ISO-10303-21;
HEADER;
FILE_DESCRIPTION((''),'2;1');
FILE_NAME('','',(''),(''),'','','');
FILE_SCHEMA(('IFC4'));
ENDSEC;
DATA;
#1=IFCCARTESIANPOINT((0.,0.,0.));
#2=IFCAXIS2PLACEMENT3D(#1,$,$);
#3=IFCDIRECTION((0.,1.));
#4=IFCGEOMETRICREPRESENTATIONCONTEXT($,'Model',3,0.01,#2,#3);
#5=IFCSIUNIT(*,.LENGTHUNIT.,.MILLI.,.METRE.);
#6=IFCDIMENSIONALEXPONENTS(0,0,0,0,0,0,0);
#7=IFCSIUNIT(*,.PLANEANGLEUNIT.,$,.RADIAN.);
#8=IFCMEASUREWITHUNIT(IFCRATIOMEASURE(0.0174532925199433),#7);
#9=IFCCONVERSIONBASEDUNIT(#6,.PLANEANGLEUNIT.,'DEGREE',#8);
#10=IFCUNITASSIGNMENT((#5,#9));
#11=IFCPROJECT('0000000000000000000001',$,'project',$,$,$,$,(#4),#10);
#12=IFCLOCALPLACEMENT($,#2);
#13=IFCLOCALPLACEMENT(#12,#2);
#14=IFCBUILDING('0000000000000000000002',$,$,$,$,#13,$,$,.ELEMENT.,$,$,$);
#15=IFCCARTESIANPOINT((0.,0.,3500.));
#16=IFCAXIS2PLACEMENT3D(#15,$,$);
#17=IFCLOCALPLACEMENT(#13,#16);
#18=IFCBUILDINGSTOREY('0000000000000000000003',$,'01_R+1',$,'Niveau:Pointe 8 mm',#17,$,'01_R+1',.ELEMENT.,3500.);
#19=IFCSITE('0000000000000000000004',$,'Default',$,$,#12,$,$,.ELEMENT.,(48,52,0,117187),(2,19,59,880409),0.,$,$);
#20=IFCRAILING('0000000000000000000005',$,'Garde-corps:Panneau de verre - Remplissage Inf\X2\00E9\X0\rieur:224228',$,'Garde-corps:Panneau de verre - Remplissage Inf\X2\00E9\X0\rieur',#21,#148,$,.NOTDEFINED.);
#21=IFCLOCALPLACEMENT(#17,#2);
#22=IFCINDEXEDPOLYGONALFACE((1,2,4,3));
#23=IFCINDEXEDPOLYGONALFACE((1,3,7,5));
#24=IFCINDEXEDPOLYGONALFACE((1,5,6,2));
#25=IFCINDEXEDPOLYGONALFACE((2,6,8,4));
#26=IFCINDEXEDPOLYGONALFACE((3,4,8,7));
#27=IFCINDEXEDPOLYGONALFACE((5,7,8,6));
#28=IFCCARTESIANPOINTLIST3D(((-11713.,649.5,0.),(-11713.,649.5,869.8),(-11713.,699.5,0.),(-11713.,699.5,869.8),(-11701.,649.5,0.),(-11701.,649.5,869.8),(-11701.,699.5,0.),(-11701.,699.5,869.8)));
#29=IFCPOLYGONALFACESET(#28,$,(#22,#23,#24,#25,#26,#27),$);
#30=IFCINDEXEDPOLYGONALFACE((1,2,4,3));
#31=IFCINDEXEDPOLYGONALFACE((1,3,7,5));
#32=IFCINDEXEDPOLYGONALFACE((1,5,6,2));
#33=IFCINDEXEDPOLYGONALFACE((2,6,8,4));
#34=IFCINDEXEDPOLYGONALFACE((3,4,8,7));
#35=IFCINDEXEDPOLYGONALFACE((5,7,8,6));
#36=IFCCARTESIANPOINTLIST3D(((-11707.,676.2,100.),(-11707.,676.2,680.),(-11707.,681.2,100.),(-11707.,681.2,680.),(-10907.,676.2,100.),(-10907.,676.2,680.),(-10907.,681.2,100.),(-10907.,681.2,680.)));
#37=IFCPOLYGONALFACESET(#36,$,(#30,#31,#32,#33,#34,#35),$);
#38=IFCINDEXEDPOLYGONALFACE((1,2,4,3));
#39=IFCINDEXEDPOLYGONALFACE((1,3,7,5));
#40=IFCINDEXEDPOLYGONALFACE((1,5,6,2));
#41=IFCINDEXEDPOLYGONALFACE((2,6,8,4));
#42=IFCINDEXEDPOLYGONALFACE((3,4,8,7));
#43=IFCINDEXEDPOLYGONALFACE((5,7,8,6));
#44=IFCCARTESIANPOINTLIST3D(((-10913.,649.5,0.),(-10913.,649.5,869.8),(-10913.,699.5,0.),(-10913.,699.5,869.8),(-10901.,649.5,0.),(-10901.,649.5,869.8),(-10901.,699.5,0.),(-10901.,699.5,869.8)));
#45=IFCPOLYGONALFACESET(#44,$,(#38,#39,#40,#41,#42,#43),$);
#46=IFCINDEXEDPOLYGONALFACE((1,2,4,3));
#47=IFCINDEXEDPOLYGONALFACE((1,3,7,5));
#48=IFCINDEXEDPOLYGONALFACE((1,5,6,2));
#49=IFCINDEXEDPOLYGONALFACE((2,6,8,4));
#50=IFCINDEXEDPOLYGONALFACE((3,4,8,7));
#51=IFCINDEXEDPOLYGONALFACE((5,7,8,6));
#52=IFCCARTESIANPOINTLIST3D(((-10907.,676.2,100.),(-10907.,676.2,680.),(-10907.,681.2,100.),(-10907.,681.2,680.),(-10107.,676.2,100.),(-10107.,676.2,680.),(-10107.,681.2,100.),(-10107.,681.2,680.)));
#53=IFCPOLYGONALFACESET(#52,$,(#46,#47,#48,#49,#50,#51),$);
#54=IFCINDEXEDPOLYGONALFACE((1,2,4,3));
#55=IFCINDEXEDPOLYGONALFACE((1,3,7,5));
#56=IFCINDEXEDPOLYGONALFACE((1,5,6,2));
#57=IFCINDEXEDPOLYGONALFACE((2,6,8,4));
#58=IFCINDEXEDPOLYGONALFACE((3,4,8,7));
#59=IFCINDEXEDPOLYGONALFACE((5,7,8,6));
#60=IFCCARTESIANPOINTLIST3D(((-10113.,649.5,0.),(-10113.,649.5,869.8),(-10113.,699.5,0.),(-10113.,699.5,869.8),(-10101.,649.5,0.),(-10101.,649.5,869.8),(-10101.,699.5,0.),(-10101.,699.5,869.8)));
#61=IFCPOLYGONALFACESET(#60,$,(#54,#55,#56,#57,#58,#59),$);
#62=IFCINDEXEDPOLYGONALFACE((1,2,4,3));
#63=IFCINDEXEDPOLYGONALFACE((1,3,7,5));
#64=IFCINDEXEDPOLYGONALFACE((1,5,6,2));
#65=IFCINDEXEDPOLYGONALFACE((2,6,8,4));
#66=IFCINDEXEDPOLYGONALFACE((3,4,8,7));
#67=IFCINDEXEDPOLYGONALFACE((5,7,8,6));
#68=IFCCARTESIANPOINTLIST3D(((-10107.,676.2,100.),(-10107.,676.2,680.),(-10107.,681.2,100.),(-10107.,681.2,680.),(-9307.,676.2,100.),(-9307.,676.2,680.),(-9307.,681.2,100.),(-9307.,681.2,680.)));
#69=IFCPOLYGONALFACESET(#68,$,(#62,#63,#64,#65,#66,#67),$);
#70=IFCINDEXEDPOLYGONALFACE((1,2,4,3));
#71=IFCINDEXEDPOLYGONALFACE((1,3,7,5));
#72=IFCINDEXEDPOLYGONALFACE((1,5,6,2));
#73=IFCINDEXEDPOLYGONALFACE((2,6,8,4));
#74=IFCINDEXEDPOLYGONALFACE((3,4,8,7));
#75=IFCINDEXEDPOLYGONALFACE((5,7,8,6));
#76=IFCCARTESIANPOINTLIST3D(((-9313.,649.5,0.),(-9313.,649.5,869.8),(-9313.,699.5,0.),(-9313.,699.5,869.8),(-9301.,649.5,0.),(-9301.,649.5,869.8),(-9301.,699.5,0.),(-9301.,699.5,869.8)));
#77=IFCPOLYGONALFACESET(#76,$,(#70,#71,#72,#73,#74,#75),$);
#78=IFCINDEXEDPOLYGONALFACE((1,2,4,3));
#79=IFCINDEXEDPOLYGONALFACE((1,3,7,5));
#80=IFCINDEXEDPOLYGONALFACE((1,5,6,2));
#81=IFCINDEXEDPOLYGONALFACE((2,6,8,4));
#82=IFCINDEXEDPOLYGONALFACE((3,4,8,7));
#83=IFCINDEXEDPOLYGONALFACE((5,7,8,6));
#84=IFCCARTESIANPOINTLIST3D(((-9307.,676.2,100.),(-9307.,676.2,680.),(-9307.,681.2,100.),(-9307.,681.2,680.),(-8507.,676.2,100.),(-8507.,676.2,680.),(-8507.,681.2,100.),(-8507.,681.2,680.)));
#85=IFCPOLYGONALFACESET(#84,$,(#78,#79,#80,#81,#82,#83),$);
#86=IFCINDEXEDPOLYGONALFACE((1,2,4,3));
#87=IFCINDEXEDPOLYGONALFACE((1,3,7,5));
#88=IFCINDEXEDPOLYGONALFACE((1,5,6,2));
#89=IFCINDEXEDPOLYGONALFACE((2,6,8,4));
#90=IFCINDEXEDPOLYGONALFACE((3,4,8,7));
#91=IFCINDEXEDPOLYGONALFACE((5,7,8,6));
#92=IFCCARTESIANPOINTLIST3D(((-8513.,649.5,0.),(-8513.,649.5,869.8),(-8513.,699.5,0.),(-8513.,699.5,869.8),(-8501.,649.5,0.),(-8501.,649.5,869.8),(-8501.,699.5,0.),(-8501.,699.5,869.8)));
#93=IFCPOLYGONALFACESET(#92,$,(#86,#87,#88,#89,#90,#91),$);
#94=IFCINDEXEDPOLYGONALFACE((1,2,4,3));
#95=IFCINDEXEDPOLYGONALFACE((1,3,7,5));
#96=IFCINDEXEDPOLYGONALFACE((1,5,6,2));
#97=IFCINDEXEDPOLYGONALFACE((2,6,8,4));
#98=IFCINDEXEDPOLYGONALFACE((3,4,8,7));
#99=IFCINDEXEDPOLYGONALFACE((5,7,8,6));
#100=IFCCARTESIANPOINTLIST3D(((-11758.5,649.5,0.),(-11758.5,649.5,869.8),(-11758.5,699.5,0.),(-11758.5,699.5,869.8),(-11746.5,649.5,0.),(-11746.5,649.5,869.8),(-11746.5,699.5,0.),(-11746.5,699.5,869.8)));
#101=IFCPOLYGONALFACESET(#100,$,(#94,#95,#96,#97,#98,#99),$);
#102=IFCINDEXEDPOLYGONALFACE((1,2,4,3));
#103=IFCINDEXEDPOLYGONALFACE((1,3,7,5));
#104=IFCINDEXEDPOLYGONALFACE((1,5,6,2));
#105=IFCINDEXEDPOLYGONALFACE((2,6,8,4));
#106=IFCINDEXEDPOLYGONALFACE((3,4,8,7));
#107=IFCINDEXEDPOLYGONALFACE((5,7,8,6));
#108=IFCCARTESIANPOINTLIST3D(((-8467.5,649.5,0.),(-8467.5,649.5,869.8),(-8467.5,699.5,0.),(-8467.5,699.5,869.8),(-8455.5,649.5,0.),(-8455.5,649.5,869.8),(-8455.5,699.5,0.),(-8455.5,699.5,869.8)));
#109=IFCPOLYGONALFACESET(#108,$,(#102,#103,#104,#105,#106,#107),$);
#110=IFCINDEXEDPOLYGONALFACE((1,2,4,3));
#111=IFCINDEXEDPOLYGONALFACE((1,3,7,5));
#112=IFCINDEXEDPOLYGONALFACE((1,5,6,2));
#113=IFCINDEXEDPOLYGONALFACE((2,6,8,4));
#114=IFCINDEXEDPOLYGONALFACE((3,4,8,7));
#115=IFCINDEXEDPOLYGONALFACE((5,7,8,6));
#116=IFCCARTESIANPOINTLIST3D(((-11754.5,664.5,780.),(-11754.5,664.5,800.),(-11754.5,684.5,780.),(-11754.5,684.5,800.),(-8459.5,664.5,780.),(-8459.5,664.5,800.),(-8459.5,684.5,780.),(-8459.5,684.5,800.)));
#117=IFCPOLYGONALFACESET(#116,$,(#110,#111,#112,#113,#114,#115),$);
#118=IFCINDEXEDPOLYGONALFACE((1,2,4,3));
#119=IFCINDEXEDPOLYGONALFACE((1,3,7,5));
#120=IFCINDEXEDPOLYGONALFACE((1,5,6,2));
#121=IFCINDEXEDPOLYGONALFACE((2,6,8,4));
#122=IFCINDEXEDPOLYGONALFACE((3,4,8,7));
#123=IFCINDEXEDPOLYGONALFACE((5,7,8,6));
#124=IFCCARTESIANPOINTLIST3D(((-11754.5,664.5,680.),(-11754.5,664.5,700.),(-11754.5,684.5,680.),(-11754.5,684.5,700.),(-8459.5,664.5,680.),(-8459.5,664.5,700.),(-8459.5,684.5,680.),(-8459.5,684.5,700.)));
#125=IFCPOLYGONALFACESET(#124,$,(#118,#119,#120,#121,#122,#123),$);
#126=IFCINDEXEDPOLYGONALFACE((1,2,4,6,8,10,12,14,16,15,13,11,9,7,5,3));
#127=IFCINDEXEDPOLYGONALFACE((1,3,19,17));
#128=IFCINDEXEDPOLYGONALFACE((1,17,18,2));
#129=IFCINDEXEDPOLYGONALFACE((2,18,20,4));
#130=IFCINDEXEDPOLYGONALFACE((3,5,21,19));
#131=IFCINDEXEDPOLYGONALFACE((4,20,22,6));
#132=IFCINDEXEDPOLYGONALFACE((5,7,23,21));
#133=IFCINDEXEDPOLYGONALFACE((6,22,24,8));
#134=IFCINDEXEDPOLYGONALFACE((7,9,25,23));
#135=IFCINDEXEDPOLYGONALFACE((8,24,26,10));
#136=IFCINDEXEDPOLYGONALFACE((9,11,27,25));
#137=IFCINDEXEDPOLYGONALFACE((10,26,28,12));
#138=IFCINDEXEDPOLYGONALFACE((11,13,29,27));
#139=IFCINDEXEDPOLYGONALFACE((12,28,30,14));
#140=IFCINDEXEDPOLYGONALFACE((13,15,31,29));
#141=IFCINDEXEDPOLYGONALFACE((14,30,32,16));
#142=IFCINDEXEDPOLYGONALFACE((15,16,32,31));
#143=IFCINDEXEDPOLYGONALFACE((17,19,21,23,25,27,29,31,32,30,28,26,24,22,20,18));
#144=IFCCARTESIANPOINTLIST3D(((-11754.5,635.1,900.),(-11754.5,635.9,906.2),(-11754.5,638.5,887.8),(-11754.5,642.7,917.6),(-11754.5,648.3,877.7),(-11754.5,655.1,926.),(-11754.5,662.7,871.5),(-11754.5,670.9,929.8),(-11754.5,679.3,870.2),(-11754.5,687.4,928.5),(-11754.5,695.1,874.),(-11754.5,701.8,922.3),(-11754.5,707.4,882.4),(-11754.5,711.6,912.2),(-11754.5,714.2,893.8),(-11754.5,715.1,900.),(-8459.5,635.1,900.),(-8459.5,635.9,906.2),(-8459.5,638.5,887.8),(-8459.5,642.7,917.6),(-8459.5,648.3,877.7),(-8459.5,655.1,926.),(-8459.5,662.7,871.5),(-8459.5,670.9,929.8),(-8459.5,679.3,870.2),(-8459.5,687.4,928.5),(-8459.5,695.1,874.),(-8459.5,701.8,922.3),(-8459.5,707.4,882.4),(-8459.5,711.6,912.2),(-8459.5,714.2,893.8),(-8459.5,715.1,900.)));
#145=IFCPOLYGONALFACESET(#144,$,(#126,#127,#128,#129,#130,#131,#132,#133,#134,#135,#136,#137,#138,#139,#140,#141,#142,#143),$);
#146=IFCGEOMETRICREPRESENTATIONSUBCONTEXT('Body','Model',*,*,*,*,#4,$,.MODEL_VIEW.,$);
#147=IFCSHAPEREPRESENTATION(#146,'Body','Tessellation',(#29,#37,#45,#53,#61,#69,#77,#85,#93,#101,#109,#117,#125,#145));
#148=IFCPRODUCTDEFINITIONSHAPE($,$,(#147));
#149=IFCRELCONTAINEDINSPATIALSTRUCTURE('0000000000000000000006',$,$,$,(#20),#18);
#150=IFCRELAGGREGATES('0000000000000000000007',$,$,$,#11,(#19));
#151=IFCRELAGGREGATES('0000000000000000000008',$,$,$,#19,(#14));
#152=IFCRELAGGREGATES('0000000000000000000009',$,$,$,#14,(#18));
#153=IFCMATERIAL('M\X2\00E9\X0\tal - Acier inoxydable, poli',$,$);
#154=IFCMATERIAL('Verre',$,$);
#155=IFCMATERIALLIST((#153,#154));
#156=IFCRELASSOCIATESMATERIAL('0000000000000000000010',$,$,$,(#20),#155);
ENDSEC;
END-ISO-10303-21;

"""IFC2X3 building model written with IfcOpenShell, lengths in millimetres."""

from ifc_helpers import new_model, entity, si_unit, converted_unit, direction, frame, frame_2d, origin, origin_2d_with_axis, place, context, subcontext, project, spatial, polyline, rectangle, outline, extrude, material, material_list, element, save


model = new_model("IFC2X3")

# Units and contexts
model_context = context("Model", 3, precision=0.01, world=origin(), true_north=direction((0.0, 1.0)))
body_context = subcontext(model_context, "Body", "Model", "MODEL_VIEW")
ifc_project = project(units=[si_unit("LENGTHUNIT", "METRE", prefix="MILLI"), converted_unit("PLANEANGLEUNIT", "DEGREE", entity("IfcRatioMeasure", 0.0174532925199433), si_unit("PLANEANGLEUNIT", "RADIAN"), dimensions=[0, 0, 0, 0, 0, 0, 0])], contexts=[model_context])

# Site, building, storey
site_placement = place(None, origin())
site = spatial("IfcSite", under=ifc_project, at=site_placement, Name="Default", CompositionType="ELEMENT", RefLatitude=(48, 52, 0, 117187), RefLongitude=(2, 19, 59, 880409), RefElevation=0.0)
building_placement = place(site_placement, origin())
building = spatial("IfcBuilding", under=site, at=building_placement, CompositionType="ELEMENT")
storey_placement = place(building_placement, frame((0.0, 0.0, 3500.0)))
storey = spatial("IfcBuildingStorey", under=building, at=storey_placement, Name="01_R+1", ObjectType="Niveau:Pointe 8 mm", LongName="01_R+1", CompositionType="ELEMENT", Elevation=3500.0)

# Railing
ifc_material_1 = material(Name="Métal - Acier inoxydable, poli")
ifc_material_2 = material(Name="Verre")
ifc_material_list_1 = material_list([ifc_material_1, ifc_material_2])
railing_1_placement = place(storey_placement, origin())
element("IfcRailing", 1, at=railing_1_placement, inside=storey, material=ifc_material_list_1, Name="Garde-corps:Panneau de verre - Remplissage Inférieur:224228", ObjectType="Garde-corps:Panneau de verre - Remplissage Inférieur", PredefinedType="NOTDEFINED", context=body_context, shape_type="SweptSolid", body=[
    extrude(rectangle(XDim=50.0, YDim=12.0, at=frame_2d((0.0, 0.0), x_axis=(1.0, 0.0))), frame((-11707.0, 674.5, 0.0), z_axis=(0.0, 0.0, 1.0), x_axis=(0.0, 1.0, 0.0)), (0.0, 0.0, 1.0), 869.8),
    extrude(rectangle(XDim=5.0, YDim=800.0, at=frame_2d((0.0, 0.0), x_axis=(1.0, 0.0))), frame((-11307.0, 678.7, 100.0), z_axis=(0.0, 0.0, 1.0), x_axis=(0.0, 1.0, 0.0)), (0.0, 0.0, 1.0), 580.0),
    extrude(rectangle(XDim=50.0, YDim=12.0, at=frame_2d((0.0, 0.0), x_axis=(1.0, 0.0))), frame((-10907.0, 674.5, 0.0), z_axis=(0.0, 0.0, 1.0), x_axis=(0.0, 1.0, 0.0)), (0.0, 0.0, 1.0), 869.8),
    extrude(rectangle(XDim=5.0, YDim=800.0, at=frame_2d((0.0, 0.0), x_axis=(1.0, 0.0))), frame((-10507.0, 678.7, 100.0), z_axis=(0.0, 0.0, 1.0), x_axis=(0.0, 1.0, 0.0)), (0.0, 0.0, 1.0), 580.0),
    extrude(rectangle(XDim=50.0, YDim=12.0, at=frame_2d((0.0, 0.0), x_axis=(1.0, 0.0))), frame((-10107.0, 674.5, 0.0), z_axis=(0.0, 0.0, 1.0), x_axis=(0.0, 1.0, 0.0)), (0.0, 0.0, 1.0), 869.8),
    extrude(rectangle(XDim=5.0, YDim=800.0, at=frame_2d((0.0, 0.0), x_axis=(1.0, 0.0))), frame((-9707.0, 678.7, 100.0), z_axis=(0.0, 0.0, 1.0), x_axis=(0.0, 1.0, 0.0)), (0.0, 0.0, 1.0), 580.0),
    extrude(rectangle(XDim=50.0, YDim=12.0, at=frame_2d((0.0, 0.0), x_axis=(1.0, 0.0))), frame((-9307.0, 674.5, 0.0), z_axis=(0.0, 0.0, 1.0), x_axis=(0.0, 1.0, 0.0)), (0.0, 0.0, 1.0), 869.8),
    extrude(rectangle(XDim=5.0, YDim=800.0, at=origin_2d_with_axis()), frame((-8907.0, 678.7, 100.0), z_axis=(0.0, 0.0, 1.0), x_axis=(0.0, 1.0, 0.0)), (0.0, 0.0, 1.0), 580.0),
    extrude(rectangle(XDim=50.0, YDim=12.0, at=frame_2d((0.0, 0.0), x_axis=(1.0, 0.0))), frame((-8507.0, 674.5, 0.0), z_axis=(0.0, 0.0, 1.0), x_axis=(0.0, 1.0, 0.0)), (0.0, 0.0, 1.0), 869.8),
    extrude(rectangle(XDim=50.0, YDim=12.0, at=frame_2d((0.0, 0.0), x_axis=(1.0, 0.0))), frame((-11752.5, 674.5, 0.0), z_axis=(0.0, 0.0, 1.0), x_axis=(0.0, 1.0, 0.0)), (0.0, 0.0, 1.0), 869.8),
    extrude(rectangle(XDim=50.0, YDim=12.0, at=frame_2d((0.0, 0.0), x_axis=(1.0, 0.0))), frame((-8461.5, 674.5, 0.0), z_axis=(0.0, 0.0, 1.0), x_axis=(0.0, 1.0, 0.0)), (0.0, 0.0, 1.0), 869.8),
    extrude(rectangle(XDim=3295.0, YDim=20.0, at=frame_2d((0.0, 0.0), x_axis=(1.0, 0.0))), frame((-10107.0, 674.5, 780.0), z_axis=(0.0, 0.0, 1.0), x_axis=(-1.0, 0.0, 0.0)), (0.0, 0.0, 1.0), 20.0),
    extrude(rectangle(XDim=3295.0, YDim=20.0, at=frame_2d((0.0, 0.0), x_axis=(1.0, 0.0))), frame((-10107.0, 674.5, 680.0), z_axis=(0.0, 0.0, 1.0), x_axis=(-1.0, 0.0, 0.0)), (0.0, 0.0, 1.0), 20.0),
    extrude(outline(polyline([(-10.9, -38.5), (1.8, -38.5), (14.2, -31.8), (24.1, -19.7), (29.8, -4.1), (30.4, 12.2), (25.8, 26.3), (16.7, 35.9), (10.9, 38.5), (-1.8, 38.5), (-14.2, 31.8), (-24.1, 19.7), (-29.8, 4.1), (-30.4, -12.2), (-25.8, -26.3), (-16.7, -35.9), (-10.9, -38.5)])), frame((-11754.5, 675.1, 900.0), z_axis=(1.0, 0.0, 0.0), x_axis=(0.0, -0.27267, 0.962108)), (0.0, 0.0, 1.0), 3295.0),
])

save(model, "model.ifc")
